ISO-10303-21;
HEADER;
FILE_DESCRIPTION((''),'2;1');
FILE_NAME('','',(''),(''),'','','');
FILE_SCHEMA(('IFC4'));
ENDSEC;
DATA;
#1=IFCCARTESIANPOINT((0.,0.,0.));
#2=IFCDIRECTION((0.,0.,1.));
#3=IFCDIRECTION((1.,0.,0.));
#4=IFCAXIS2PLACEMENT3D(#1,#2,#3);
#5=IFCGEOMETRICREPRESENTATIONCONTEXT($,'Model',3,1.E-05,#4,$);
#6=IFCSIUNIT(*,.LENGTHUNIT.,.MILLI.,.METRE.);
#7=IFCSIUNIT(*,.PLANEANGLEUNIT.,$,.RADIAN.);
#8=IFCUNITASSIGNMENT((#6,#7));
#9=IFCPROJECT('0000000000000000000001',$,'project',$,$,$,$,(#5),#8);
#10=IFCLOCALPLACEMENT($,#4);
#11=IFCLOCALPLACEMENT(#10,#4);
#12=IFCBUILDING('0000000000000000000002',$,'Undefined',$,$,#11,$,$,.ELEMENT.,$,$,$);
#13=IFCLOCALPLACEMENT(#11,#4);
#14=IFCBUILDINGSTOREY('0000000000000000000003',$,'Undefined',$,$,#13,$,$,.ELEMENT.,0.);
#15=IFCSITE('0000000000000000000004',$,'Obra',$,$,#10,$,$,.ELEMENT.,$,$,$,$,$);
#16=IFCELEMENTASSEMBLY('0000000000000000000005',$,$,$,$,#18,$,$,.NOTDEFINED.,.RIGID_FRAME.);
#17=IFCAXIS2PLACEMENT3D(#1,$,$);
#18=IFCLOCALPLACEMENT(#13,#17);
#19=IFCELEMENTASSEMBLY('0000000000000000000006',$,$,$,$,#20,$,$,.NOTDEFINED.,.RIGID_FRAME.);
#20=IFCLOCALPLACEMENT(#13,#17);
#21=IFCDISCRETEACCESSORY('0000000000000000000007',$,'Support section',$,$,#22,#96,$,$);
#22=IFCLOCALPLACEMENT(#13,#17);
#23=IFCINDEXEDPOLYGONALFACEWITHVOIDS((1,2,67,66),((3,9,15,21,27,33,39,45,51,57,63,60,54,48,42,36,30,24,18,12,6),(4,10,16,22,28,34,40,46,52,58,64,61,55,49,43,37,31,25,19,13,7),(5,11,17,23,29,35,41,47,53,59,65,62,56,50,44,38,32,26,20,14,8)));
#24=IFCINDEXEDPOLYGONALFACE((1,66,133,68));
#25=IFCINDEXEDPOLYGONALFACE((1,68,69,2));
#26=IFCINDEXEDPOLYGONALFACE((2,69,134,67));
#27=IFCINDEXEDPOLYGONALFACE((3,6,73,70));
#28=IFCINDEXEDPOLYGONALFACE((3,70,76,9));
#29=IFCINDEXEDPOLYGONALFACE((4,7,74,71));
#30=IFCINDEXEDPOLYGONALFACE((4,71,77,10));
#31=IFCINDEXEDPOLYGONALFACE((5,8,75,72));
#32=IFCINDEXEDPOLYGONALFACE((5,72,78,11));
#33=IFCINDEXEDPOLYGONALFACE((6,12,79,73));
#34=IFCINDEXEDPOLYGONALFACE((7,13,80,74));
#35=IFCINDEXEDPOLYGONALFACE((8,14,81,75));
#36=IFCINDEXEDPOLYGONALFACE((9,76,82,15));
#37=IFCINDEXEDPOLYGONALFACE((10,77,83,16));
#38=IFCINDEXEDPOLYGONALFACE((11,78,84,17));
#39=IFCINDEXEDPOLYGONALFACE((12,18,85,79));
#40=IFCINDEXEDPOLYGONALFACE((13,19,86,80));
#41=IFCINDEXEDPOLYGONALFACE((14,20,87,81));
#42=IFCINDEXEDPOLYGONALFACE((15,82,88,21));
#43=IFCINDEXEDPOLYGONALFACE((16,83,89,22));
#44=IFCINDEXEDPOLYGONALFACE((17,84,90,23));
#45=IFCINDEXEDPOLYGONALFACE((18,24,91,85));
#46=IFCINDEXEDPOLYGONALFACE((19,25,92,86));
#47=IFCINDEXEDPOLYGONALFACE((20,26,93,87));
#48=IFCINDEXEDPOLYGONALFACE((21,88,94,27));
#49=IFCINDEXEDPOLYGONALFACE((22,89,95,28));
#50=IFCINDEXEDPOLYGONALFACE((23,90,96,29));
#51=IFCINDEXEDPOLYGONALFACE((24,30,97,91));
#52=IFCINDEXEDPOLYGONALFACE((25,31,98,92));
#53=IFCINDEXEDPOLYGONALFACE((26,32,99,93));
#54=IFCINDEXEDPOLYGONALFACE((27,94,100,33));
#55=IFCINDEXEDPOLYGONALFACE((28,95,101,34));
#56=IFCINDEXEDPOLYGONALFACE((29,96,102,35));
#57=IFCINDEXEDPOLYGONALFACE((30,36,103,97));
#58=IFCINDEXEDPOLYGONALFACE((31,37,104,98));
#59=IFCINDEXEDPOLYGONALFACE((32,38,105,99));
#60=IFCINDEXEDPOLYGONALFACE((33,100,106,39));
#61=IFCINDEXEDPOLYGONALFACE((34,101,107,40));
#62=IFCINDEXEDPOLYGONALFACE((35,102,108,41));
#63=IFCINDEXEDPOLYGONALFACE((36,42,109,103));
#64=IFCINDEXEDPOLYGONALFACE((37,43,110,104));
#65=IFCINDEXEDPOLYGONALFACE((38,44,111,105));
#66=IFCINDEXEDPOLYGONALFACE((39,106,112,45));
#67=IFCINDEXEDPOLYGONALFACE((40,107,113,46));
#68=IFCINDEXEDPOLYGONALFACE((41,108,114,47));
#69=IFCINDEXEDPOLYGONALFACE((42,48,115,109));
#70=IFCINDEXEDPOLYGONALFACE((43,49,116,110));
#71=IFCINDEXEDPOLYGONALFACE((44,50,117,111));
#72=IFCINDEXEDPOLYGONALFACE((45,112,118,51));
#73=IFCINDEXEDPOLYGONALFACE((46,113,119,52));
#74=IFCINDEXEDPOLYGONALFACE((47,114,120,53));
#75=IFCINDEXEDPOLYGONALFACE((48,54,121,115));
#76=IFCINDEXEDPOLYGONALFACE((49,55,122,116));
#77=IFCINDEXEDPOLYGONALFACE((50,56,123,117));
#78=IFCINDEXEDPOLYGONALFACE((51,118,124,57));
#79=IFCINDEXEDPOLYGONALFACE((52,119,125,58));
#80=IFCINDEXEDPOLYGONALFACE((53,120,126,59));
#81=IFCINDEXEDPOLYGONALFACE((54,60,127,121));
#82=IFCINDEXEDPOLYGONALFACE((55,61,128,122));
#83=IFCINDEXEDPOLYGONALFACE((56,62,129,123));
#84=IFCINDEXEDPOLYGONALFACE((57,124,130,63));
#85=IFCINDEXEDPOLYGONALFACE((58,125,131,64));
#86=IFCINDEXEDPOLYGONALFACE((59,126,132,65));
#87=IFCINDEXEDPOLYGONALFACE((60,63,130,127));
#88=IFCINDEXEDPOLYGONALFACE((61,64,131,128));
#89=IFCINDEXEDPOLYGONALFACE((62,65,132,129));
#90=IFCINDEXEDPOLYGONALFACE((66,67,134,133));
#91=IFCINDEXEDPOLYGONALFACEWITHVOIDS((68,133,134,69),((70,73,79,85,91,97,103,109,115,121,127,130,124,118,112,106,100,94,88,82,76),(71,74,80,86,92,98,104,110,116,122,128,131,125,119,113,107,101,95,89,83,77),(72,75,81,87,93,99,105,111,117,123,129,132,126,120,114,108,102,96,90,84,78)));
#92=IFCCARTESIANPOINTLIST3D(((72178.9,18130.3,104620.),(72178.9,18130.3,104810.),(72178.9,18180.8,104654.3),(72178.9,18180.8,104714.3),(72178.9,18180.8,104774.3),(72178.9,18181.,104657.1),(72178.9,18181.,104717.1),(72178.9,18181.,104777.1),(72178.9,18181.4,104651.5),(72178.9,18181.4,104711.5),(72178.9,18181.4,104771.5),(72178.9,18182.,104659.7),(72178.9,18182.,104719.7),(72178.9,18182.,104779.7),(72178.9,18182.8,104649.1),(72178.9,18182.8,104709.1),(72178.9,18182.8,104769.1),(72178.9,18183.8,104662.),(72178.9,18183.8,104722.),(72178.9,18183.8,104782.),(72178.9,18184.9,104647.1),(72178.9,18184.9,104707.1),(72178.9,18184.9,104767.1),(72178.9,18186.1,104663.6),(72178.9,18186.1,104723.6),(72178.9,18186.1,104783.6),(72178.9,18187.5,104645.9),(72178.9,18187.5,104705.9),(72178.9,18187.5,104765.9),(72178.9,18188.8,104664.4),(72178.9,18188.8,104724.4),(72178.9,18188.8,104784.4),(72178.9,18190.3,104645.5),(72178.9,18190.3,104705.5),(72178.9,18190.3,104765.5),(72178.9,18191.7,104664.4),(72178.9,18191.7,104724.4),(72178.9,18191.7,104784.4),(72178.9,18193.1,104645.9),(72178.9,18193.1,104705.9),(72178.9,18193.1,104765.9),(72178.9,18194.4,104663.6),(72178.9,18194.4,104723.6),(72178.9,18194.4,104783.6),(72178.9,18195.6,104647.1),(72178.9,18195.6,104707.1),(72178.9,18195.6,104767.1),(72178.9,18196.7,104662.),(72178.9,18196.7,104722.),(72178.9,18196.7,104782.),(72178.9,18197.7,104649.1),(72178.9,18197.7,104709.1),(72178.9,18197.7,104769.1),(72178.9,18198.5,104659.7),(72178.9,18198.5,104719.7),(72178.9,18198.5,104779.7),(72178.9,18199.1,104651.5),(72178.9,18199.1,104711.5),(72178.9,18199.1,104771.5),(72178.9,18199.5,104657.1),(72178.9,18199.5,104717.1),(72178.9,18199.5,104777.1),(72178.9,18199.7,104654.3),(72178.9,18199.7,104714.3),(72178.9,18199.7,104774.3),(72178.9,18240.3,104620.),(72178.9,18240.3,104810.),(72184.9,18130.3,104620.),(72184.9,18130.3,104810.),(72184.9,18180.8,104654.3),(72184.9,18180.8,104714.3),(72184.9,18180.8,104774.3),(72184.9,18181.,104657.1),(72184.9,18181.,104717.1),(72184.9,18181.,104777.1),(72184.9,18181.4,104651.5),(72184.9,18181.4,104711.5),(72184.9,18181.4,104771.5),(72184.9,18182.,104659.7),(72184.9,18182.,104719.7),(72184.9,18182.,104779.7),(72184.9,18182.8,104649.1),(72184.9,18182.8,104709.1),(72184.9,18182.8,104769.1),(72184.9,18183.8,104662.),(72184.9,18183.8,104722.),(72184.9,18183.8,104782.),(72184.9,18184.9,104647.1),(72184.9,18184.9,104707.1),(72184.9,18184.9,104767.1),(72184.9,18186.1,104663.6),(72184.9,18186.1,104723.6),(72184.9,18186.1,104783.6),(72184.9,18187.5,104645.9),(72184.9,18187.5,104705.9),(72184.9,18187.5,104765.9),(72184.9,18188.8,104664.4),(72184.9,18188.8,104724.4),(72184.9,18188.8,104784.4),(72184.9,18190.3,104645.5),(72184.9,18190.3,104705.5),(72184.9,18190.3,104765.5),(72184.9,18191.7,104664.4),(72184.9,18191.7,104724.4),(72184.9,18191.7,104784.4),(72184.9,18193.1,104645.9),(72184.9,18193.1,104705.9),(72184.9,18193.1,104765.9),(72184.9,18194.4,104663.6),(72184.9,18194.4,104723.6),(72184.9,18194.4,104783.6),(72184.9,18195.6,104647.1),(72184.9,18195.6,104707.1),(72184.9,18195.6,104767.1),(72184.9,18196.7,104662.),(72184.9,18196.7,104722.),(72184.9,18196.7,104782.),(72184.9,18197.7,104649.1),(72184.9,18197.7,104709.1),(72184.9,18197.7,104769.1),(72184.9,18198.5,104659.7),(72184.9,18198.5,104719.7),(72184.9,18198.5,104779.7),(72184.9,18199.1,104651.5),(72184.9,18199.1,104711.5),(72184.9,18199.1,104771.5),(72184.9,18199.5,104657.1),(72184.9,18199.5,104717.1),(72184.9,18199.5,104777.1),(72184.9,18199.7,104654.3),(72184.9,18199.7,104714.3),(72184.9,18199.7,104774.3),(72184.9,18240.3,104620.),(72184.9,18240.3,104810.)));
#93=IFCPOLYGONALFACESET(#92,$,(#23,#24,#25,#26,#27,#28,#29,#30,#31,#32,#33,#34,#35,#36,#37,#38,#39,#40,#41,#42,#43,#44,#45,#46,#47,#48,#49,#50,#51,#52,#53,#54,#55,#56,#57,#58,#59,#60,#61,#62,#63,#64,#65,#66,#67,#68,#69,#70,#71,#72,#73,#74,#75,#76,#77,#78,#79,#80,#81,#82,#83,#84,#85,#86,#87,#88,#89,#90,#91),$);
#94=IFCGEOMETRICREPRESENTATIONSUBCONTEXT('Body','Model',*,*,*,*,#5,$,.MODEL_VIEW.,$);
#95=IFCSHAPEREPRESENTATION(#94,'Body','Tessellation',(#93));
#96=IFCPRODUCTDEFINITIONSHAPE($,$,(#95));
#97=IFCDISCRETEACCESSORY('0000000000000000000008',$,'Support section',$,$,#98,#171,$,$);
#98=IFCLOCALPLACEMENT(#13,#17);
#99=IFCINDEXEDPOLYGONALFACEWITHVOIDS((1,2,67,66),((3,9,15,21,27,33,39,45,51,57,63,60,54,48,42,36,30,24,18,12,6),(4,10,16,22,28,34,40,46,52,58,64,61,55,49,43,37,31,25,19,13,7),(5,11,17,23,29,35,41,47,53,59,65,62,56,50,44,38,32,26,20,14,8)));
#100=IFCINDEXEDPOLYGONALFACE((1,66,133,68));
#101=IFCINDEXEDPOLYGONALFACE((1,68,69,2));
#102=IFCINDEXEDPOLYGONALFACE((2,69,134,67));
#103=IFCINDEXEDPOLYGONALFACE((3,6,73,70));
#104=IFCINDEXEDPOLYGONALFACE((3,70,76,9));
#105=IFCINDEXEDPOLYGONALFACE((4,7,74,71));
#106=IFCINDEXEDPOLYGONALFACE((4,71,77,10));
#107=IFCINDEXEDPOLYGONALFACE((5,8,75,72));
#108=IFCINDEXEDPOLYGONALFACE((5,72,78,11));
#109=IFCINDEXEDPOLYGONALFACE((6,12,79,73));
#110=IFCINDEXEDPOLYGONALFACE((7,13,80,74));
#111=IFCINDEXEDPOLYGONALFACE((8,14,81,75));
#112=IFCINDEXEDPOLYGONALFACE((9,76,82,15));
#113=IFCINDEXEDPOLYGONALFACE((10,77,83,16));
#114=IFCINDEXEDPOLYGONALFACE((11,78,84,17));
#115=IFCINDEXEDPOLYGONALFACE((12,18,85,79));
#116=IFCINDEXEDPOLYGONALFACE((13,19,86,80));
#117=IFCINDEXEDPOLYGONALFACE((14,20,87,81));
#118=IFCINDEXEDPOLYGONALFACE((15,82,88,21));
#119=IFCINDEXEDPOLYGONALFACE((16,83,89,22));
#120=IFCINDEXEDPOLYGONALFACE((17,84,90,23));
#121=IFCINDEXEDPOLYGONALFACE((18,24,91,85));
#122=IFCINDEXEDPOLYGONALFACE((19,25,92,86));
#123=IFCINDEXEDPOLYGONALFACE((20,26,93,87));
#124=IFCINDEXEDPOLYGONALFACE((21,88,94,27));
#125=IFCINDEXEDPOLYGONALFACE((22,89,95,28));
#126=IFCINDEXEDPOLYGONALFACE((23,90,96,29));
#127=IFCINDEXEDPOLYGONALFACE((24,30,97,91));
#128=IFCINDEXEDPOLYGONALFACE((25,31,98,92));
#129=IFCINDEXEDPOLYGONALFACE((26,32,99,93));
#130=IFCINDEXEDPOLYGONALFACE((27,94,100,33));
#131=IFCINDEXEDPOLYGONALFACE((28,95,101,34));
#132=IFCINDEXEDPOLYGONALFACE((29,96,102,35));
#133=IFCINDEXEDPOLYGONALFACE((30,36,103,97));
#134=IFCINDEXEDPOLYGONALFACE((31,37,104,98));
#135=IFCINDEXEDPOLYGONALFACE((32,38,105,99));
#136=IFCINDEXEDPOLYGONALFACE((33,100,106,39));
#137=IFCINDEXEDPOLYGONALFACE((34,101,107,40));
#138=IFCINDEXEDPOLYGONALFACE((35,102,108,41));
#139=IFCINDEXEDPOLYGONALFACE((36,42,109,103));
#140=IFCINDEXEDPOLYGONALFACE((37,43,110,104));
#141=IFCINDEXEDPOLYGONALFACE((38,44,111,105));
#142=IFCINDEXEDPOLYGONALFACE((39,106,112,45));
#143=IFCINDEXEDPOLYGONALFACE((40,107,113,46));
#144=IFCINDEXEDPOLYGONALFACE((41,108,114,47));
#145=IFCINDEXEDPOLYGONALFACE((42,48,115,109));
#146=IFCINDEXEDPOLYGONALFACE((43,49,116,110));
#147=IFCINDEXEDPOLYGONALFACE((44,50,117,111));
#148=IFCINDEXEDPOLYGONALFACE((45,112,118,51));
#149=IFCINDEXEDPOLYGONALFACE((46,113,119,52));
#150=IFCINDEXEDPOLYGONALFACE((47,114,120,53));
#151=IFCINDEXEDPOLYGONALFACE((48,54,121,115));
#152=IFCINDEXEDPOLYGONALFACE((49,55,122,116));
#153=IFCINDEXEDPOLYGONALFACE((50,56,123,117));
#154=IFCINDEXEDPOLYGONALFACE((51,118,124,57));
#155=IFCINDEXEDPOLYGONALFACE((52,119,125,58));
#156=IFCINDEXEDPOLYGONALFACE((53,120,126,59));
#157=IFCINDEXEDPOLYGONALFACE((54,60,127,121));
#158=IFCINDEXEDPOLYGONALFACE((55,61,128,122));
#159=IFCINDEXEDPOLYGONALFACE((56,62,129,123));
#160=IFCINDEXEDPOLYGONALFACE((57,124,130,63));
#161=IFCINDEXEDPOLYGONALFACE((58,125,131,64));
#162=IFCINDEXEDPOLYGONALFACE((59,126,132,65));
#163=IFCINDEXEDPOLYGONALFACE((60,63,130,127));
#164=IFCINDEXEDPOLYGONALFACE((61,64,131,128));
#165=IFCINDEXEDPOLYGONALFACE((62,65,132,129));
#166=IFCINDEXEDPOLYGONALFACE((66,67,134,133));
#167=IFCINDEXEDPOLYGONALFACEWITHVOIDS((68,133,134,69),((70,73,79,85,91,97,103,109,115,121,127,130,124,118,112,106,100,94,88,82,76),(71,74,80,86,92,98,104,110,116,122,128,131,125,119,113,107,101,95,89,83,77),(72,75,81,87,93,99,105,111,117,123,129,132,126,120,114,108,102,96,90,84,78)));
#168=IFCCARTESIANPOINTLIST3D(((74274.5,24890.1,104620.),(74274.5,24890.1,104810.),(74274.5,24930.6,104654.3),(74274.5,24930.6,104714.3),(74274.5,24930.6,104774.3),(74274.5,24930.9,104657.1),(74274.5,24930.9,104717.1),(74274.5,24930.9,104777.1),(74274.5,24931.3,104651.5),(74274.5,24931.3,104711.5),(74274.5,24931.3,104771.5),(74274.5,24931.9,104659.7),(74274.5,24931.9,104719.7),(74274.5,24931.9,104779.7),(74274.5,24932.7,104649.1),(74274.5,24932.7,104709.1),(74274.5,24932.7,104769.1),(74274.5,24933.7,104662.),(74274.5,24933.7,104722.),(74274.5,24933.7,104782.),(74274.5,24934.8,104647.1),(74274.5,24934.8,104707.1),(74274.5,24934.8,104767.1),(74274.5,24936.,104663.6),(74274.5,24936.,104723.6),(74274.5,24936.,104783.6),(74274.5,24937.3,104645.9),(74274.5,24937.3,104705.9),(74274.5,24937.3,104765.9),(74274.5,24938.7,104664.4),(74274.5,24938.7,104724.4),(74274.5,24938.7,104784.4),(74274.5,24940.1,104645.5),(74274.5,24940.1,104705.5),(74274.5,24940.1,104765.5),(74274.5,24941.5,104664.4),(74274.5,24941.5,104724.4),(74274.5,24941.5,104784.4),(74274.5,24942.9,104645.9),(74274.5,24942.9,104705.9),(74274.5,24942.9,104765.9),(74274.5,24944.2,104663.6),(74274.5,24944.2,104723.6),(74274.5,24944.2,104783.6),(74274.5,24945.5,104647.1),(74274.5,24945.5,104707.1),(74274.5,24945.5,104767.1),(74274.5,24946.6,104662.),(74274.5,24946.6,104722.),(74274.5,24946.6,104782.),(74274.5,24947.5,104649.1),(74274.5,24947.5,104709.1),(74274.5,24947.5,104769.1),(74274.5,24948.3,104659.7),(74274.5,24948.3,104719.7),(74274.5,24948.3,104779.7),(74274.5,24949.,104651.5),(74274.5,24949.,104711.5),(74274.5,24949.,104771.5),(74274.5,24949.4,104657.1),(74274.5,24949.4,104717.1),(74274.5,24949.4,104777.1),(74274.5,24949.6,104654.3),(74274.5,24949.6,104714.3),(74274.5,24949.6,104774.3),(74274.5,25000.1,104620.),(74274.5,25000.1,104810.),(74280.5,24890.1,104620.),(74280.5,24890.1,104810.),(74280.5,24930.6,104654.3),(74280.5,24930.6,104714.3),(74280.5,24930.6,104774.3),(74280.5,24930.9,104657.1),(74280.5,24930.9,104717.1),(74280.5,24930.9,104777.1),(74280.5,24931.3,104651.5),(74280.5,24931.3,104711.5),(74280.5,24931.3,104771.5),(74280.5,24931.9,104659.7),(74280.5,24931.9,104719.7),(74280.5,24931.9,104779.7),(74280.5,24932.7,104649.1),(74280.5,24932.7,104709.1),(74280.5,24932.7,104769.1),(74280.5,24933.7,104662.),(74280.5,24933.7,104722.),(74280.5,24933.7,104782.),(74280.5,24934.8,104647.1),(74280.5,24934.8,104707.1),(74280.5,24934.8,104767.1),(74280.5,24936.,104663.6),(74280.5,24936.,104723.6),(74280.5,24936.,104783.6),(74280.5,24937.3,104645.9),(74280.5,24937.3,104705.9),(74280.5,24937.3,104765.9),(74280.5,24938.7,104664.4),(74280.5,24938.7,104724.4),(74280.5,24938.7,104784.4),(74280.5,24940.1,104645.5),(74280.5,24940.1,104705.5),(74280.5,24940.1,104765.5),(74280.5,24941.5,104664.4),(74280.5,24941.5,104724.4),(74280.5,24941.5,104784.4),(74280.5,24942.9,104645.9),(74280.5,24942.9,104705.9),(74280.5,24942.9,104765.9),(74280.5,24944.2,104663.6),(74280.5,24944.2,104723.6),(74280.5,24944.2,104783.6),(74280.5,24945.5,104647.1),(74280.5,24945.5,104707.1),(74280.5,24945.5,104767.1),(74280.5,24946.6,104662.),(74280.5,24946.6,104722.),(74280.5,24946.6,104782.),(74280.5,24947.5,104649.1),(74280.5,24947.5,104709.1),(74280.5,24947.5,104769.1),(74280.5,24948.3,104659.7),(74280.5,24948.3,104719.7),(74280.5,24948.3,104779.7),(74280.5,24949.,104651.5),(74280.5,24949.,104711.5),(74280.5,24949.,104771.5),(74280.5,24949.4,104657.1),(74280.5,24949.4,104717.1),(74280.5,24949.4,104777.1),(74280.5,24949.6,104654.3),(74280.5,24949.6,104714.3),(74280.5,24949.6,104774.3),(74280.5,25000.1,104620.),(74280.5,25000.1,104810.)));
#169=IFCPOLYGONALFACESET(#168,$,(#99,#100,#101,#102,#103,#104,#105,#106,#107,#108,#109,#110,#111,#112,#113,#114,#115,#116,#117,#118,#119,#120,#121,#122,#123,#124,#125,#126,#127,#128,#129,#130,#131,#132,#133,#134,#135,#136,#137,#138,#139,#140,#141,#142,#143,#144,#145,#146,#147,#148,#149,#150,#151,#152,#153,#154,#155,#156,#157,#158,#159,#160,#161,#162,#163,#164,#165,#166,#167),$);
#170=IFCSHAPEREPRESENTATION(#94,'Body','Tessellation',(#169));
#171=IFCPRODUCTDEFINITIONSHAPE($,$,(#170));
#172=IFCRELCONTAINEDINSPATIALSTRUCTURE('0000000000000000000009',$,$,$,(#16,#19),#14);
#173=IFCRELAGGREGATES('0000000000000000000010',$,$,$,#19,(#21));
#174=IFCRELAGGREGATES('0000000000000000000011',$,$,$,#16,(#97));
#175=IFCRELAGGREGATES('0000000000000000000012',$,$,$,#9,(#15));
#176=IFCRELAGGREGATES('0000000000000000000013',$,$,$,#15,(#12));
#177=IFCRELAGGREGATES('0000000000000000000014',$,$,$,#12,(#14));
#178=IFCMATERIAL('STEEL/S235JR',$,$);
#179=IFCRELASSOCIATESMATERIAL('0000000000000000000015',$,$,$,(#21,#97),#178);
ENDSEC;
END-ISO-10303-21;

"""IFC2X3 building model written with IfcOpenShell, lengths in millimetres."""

from ifc_helpers import new_model, si_unit, frame, origin_with_axes, origin_2d_with_axis, place, context, subcontext, project, spatial, rectangle, circle, extrude, source, transform, mapped, material, element, aggregate, save


model = new_model("IFC2X3")

# Units and contexts
model_context = context("Model", 3, precision=1e-05, world=origin_with_axes())
body_context = subcontext(model_context, "Body", "Model", "MODEL_VIEW")
ifc_project = project(units=[si_unit("LENGTHUNIT", "METRE", prefix="MILLI"), si_unit("PLANEANGLEUNIT", "RADIAN")], contexts=[model_context])

# Site, building, storey
site_placement = place(None, origin_with_axes())
site = spatial("IfcSite", under=ifc_project, at=site_placement, Name="Obra", CompositionType="ELEMENT")
building_placement = place(site_placement, origin_with_axes())
building = spatial("IfcBuilding", under=site, at=building_placement, Name="Undefined", CompositionType="ELEMENT")
storey_placement = place(building_placement, origin_with_axes())
storey = spatial("IfcBuildingStorey", under=building, at=storey_placement, Name="Undefined", CompositionType="ELEMENT", Elevation=0.0)

# Element assembly
ifc_material = material(Name="STEEL/S235JR")
assembly_1_placement = place(storey_placement, origin_with_axes())
assembly_1 = element("IfcElementAssembly", 1, at=assembly_1_placement, inside=storey, AssemblyPlace="NOTDEFINED", PredefinedType="RIGID_FRAME")

# Shared definitions
shared_shape_1 = source(origin_with_axes(), body_context, "Body", "SweptSolid", [
    extrude(circle(Radius=9.5, at=origin_2d_with_axis()), frame((0.0, -9.2, 0.0), z_axis=(0.0, 1.0, 0.0), x_axis=(1.0, 0.0, 0.0)), (0.0, 0.0, 1.0), 6.2),
])

# Element assembly, discrete accessory, opening
assembly_2_placement = place(storey_placement, origin_with_axes())
assembly_2 = element("IfcElementAssembly", 2, at=assembly_2_placement, inside=storey, AssemblyPlace="NOTDEFINED", PredefinedType="RIGID_FRAME")
discrete_accessory_1_placement = place(assembly_2_placement, frame((72181.9, 18185.3, 104620.0), z_axis=(0.0, 0.0, 1.0), x_axis=(0.0, -1.0, 0.0)))
discrete_accessory_1 = element("IfcDiscreteAccessory", 3, at=discrete_accessory_1_placement, material=ifc_material, Name="Support section", context=body_context, shape_type="SweptSolid", body=[
    extrude(rectangle(XDim=6.0, YDim=110.0, at=origin_2d_with_axis()), frame((0.0, 0.0, 190.0), z_axis=(0.0, 0.0, -1.0), x_axis=(0.0, 1.0, 0.0)), (0.0, 0.0, 1.0), 190.0),
])
opening_1_placement = place(assembly_2_placement, frame((72175.8, 18140.3, 104835.0), z_axis=(0.0, 1.0, 0.0), x_axis=(0.0, 0.0, -1.0)))
element("IfcOpeningElement", 4, at=opening_1_placement, cuts=discrete_accessory_1, ObjectType="Opening", context=body_context, shape_type="MappedRepresentation", body=[
    mapped(shared_shape_1, transform((60.0, 0.0, 50.0))),
    mapped(shared_shape_1, transform((120.0, 0.0, 50.0))),
    mapped(shared_shape_1, transform((180.0, 0.0, 50.0))),
])
aggregate(assembly_2, [discrete_accessory_1])

# Discrete accessory, opening
discrete_accessory_2_placement = place(assembly_1_placement, frame((74277.5, 24945.1, 104620.0), z_axis=(0.0, 0.0, 1.0), x_axis=(-0.000002, 1.0, 0.0)))
discrete_accessory_2 = element("IfcDiscreteAccessory", 5, at=discrete_accessory_2_placement, material=ifc_material, Name="Support section", context=body_context, shape_type="SweptSolid", body=[
    extrude(rectangle(XDim=6.0, YDim=110.0, at=origin_2d_with_axis()), frame((0.0, 0.0, 190.0), z_axis=(0.0, 0.0, -1.0), x_axis=(0.0, 1.0, 0.0)), (0.0, 0.0, 1.0), 190.0),
])
opening_2_placement = place(assembly_1_placement, frame((74283.6, 24990.1, 104835.0), z_axis=(0.000002, -1.0, 0.0), x_axis=(0.0, 0.0, -1.0)))
element("IfcOpeningElement", 6, at=opening_2_placement, cuts=discrete_accessory_2, ObjectType="Opening", context=body_context, shape_type="MappedRepresentation", body=[
    mapped(shared_shape_1, transform((60.0, 0.0, 50.0))),
    mapped(shared_shape_1, transform((120.0, 0.0, 50.0))),
    mapped(shared_shape_1, transform((180.0, 0.0, 50.0))),
])
aggregate(assembly_1, [discrete_accessory_2])

save(model, "model.ifc")
